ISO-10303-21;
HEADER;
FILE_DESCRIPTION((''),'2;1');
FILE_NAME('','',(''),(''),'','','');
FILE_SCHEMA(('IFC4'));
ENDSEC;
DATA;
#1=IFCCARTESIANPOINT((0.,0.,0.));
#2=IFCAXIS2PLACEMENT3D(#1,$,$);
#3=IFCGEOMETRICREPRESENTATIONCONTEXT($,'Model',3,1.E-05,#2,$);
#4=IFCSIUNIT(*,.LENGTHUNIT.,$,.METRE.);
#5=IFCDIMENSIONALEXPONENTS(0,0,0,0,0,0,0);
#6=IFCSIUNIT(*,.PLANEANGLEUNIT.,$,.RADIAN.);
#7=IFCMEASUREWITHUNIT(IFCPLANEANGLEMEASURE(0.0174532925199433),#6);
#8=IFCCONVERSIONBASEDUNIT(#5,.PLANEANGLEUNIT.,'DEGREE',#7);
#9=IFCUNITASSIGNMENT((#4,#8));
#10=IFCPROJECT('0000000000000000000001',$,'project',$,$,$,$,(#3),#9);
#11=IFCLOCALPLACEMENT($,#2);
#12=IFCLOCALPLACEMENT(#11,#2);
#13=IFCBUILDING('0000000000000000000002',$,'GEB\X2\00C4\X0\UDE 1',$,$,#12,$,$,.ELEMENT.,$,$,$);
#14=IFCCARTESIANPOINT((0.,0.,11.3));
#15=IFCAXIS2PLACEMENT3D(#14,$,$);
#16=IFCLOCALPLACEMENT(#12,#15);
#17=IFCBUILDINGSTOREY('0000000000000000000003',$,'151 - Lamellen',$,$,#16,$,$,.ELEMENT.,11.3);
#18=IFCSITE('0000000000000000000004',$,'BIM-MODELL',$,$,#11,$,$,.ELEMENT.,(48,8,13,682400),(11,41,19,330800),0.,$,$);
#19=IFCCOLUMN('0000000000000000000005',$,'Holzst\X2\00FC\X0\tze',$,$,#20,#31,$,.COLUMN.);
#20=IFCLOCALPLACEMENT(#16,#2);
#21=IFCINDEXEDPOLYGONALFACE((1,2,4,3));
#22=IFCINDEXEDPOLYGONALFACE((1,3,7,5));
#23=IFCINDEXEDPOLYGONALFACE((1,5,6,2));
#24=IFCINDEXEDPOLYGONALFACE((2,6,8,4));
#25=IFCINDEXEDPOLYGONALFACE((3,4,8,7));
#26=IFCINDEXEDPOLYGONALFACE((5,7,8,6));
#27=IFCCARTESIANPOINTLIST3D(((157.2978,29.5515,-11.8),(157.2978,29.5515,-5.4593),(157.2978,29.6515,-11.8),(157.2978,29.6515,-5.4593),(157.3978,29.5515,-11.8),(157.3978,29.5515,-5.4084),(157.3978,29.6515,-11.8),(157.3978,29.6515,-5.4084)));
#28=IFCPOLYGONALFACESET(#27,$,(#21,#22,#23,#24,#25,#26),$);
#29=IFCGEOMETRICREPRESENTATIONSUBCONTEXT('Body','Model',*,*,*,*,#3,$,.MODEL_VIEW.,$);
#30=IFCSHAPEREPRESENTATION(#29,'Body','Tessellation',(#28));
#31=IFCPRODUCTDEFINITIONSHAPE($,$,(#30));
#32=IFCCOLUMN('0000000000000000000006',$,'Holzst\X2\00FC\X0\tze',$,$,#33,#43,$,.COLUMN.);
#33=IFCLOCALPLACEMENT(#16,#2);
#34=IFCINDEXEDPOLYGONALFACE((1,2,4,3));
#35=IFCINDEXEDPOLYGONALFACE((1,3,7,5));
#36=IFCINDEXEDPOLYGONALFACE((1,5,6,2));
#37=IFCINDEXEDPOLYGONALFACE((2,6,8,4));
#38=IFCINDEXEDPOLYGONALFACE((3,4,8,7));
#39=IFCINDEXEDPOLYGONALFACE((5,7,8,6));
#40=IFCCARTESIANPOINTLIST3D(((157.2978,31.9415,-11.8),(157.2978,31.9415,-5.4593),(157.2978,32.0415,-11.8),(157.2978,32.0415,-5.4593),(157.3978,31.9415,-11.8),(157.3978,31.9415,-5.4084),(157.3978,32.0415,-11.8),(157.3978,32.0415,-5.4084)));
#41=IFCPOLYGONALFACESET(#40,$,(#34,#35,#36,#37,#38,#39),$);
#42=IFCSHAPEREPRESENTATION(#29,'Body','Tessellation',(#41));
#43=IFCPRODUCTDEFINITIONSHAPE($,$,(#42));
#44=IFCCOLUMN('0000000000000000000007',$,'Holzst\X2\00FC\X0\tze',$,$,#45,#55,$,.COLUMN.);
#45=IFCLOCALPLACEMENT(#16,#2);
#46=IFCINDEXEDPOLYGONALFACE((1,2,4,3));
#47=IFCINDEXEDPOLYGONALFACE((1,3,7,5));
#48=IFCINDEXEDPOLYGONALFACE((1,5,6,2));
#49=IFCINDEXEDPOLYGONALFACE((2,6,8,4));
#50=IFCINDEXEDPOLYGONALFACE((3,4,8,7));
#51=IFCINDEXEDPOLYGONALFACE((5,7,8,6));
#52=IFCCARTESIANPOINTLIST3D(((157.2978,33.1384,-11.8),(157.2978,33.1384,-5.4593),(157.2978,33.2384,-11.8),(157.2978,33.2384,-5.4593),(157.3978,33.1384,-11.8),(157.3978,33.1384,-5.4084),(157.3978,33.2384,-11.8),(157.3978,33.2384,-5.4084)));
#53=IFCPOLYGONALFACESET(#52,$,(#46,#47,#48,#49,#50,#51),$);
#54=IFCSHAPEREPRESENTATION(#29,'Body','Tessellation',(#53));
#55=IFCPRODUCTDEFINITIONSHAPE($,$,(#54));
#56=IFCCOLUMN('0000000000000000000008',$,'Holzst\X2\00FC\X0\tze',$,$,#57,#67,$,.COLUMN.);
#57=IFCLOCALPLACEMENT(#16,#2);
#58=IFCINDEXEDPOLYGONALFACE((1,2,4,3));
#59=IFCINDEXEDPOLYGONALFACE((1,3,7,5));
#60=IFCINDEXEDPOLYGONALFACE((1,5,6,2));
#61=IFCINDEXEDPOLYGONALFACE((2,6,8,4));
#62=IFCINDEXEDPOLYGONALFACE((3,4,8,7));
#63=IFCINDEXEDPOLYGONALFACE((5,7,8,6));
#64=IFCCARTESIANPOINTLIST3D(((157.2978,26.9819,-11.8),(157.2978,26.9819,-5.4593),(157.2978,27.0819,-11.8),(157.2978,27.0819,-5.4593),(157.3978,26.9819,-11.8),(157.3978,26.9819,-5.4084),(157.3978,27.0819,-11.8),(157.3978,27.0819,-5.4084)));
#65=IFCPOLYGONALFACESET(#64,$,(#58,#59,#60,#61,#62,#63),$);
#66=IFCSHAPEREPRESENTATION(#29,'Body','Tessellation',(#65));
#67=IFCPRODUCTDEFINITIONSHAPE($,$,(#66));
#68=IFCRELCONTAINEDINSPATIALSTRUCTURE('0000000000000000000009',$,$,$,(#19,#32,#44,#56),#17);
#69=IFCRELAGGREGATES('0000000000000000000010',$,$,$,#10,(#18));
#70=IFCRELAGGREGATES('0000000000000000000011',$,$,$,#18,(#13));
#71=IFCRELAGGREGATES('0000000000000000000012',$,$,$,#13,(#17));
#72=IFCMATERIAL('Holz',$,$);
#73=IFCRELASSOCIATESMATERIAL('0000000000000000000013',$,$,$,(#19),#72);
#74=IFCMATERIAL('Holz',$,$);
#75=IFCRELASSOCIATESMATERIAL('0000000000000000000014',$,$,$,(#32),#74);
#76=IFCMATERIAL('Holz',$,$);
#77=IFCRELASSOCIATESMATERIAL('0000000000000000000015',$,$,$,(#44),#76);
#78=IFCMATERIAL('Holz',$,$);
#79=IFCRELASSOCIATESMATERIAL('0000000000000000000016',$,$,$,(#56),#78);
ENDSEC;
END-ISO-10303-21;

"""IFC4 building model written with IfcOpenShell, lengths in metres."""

from ifc_helpers import new_model, entity, si_unit, converted_unit, frame, frame_2d, origin, origin_with_axes, place, context, subcontext, project, spatial, rectangle, extrude, clip, halfspace, material, element, save


model = new_model("IFC4")

# Units and contexts
model_context = context("Model", 3, precision=1e-05, world=origin())
body_context = subcontext(model_context, "Body", "Model", "MODEL_VIEW")
ifc_project = project(units=[si_unit("LENGTHUNIT", "METRE"), converted_unit("PLANEANGLEUNIT", "DEGREE", entity("IfcPlaneAngleMeasure", 0.0174532925199433), si_unit("PLANEANGLEUNIT", "RADIAN"), dimensions=[0, 0, 0, 0, 0, 0, 0])], contexts=[model_context])

# Site, building, storey
site_placement = place(None, origin())
site = spatial("IfcSite", under=ifc_project, at=site_placement, Name="BIM-MODELL", CompositionType="ELEMENT", RefLatitude=(48, 8, 13, 682400), RefLongitude=(11, 41, 19, 330800), RefElevation=0.0)
building_placement = place(site_placement, origin())
building = spatial("IfcBuilding", under=site, at=building_placement, Name="GEBÄUDE 1", CompositionType="ELEMENT")
storey_placement = place(building_placement, frame((0.0, 0.0, 11.3)))
storey = spatial("IfcBuildingStorey", under=building, at=storey_placement, Name="151 - Lamellen", CompositionType="ELEMENT", Elevation=11.3)

# Columns
ifc_material_1 = material(Name="Holz")
column_1_placement = place(storey_placement, frame((157.3978, 29.5515, -11.8)))
element("IfcColumn", 1, at=column_1_placement, inside=storey, material=ifc_material_1, Name="Holzstütze", PredefinedType="COLUMN", context=body_context, shape_type="Clipping", body=[
    clip(extrude(rectangle(XDim=0.1, YDim=0.1, at=frame_2d((-0.05, 0.05), x_axis=(0.0, 1.0))), origin_with_axes(), (0.0, 0.0, 1.0), 6.3916), halfspace(frame((-0.05, 0.05, 6.3661), z_axis=(0.45399, 0.0, -0.891007), x_axis=(-0.891007, 0.0, -0.45399)), True)),
])
ifc_material_2 = material(Name="Holz")
column_2_placement = place(storey_placement, frame((157.3978, 31.9415, -11.8)))
element("IfcColumn", 2, at=column_2_placement, inside=storey, material=ifc_material_2, Name="Holzstütze", PredefinedType="COLUMN", context=body_context, shape_type="Clipping", body=[
    clip(extrude(rectangle(XDim=0.1, YDim=0.1, at=frame_2d((-0.05, 0.05), x_axis=(0.0, 1.0))), origin_with_axes(), (0.0, 0.0, 1.0), 6.3916), halfspace(frame((-0.05, 0.05, 6.3661), z_axis=(0.45399, 0.0, -0.891007), x_axis=(-0.891007, 0.0, -0.45399)), True)),
])
ifc_material_3 = material(Name="Holz")
column_3_placement = place(storey_placement, frame((157.3978, 33.1384, -11.8)))
element("IfcColumn", 3, at=column_3_placement, inside=storey, material=ifc_material_3, Name="Holzstütze", PredefinedType="COLUMN", context=body_context, shape_type="Clipping", body=[
    clip(extrude(rectangle(XDim=0.1, YDim=0.1, at=frame_2d((-0.05, 0.05), x_axis=(0.0, 1.0))), origin_with_axes(), (0.0, 0.0, 1.0), 6.3916), halfspace(frame((-0.05, 0.05, 6.3661), z_axis=(0.45399, 0.0, -0.891007), x_axis=(-0.891007, 0.0, -0.45399)), True)),
])
ifc_material_4 = material(Name="Holz")
column_4_placement = place(storey_placement, frame((157.3978, 26.9819, -11.8)))
element("IfcColumn", 4, at=column_4_placement, inside=storey, material=ifc_material_4, Name="Holzstütze", PredefinedType="COLUMN", context=body_context, shape_type="Clipping", body=[
    clip(extrude(rectangle(XDim=0.1, YDim=0.1, at=frame_2d((-0.05, 0.05), x_axis=(0.0, 1.0))), origin_with_axes(), (0.0, 0.0, 1.0), 6.3916), halfspace(frame((-0.05, 0.05, 6.3661), z_axis=(0.45399, 0.0, -0.891007), x_axis=(-0.891007, 0.0, -0.45399)), True)),
])

save(model, "model.ifc")
